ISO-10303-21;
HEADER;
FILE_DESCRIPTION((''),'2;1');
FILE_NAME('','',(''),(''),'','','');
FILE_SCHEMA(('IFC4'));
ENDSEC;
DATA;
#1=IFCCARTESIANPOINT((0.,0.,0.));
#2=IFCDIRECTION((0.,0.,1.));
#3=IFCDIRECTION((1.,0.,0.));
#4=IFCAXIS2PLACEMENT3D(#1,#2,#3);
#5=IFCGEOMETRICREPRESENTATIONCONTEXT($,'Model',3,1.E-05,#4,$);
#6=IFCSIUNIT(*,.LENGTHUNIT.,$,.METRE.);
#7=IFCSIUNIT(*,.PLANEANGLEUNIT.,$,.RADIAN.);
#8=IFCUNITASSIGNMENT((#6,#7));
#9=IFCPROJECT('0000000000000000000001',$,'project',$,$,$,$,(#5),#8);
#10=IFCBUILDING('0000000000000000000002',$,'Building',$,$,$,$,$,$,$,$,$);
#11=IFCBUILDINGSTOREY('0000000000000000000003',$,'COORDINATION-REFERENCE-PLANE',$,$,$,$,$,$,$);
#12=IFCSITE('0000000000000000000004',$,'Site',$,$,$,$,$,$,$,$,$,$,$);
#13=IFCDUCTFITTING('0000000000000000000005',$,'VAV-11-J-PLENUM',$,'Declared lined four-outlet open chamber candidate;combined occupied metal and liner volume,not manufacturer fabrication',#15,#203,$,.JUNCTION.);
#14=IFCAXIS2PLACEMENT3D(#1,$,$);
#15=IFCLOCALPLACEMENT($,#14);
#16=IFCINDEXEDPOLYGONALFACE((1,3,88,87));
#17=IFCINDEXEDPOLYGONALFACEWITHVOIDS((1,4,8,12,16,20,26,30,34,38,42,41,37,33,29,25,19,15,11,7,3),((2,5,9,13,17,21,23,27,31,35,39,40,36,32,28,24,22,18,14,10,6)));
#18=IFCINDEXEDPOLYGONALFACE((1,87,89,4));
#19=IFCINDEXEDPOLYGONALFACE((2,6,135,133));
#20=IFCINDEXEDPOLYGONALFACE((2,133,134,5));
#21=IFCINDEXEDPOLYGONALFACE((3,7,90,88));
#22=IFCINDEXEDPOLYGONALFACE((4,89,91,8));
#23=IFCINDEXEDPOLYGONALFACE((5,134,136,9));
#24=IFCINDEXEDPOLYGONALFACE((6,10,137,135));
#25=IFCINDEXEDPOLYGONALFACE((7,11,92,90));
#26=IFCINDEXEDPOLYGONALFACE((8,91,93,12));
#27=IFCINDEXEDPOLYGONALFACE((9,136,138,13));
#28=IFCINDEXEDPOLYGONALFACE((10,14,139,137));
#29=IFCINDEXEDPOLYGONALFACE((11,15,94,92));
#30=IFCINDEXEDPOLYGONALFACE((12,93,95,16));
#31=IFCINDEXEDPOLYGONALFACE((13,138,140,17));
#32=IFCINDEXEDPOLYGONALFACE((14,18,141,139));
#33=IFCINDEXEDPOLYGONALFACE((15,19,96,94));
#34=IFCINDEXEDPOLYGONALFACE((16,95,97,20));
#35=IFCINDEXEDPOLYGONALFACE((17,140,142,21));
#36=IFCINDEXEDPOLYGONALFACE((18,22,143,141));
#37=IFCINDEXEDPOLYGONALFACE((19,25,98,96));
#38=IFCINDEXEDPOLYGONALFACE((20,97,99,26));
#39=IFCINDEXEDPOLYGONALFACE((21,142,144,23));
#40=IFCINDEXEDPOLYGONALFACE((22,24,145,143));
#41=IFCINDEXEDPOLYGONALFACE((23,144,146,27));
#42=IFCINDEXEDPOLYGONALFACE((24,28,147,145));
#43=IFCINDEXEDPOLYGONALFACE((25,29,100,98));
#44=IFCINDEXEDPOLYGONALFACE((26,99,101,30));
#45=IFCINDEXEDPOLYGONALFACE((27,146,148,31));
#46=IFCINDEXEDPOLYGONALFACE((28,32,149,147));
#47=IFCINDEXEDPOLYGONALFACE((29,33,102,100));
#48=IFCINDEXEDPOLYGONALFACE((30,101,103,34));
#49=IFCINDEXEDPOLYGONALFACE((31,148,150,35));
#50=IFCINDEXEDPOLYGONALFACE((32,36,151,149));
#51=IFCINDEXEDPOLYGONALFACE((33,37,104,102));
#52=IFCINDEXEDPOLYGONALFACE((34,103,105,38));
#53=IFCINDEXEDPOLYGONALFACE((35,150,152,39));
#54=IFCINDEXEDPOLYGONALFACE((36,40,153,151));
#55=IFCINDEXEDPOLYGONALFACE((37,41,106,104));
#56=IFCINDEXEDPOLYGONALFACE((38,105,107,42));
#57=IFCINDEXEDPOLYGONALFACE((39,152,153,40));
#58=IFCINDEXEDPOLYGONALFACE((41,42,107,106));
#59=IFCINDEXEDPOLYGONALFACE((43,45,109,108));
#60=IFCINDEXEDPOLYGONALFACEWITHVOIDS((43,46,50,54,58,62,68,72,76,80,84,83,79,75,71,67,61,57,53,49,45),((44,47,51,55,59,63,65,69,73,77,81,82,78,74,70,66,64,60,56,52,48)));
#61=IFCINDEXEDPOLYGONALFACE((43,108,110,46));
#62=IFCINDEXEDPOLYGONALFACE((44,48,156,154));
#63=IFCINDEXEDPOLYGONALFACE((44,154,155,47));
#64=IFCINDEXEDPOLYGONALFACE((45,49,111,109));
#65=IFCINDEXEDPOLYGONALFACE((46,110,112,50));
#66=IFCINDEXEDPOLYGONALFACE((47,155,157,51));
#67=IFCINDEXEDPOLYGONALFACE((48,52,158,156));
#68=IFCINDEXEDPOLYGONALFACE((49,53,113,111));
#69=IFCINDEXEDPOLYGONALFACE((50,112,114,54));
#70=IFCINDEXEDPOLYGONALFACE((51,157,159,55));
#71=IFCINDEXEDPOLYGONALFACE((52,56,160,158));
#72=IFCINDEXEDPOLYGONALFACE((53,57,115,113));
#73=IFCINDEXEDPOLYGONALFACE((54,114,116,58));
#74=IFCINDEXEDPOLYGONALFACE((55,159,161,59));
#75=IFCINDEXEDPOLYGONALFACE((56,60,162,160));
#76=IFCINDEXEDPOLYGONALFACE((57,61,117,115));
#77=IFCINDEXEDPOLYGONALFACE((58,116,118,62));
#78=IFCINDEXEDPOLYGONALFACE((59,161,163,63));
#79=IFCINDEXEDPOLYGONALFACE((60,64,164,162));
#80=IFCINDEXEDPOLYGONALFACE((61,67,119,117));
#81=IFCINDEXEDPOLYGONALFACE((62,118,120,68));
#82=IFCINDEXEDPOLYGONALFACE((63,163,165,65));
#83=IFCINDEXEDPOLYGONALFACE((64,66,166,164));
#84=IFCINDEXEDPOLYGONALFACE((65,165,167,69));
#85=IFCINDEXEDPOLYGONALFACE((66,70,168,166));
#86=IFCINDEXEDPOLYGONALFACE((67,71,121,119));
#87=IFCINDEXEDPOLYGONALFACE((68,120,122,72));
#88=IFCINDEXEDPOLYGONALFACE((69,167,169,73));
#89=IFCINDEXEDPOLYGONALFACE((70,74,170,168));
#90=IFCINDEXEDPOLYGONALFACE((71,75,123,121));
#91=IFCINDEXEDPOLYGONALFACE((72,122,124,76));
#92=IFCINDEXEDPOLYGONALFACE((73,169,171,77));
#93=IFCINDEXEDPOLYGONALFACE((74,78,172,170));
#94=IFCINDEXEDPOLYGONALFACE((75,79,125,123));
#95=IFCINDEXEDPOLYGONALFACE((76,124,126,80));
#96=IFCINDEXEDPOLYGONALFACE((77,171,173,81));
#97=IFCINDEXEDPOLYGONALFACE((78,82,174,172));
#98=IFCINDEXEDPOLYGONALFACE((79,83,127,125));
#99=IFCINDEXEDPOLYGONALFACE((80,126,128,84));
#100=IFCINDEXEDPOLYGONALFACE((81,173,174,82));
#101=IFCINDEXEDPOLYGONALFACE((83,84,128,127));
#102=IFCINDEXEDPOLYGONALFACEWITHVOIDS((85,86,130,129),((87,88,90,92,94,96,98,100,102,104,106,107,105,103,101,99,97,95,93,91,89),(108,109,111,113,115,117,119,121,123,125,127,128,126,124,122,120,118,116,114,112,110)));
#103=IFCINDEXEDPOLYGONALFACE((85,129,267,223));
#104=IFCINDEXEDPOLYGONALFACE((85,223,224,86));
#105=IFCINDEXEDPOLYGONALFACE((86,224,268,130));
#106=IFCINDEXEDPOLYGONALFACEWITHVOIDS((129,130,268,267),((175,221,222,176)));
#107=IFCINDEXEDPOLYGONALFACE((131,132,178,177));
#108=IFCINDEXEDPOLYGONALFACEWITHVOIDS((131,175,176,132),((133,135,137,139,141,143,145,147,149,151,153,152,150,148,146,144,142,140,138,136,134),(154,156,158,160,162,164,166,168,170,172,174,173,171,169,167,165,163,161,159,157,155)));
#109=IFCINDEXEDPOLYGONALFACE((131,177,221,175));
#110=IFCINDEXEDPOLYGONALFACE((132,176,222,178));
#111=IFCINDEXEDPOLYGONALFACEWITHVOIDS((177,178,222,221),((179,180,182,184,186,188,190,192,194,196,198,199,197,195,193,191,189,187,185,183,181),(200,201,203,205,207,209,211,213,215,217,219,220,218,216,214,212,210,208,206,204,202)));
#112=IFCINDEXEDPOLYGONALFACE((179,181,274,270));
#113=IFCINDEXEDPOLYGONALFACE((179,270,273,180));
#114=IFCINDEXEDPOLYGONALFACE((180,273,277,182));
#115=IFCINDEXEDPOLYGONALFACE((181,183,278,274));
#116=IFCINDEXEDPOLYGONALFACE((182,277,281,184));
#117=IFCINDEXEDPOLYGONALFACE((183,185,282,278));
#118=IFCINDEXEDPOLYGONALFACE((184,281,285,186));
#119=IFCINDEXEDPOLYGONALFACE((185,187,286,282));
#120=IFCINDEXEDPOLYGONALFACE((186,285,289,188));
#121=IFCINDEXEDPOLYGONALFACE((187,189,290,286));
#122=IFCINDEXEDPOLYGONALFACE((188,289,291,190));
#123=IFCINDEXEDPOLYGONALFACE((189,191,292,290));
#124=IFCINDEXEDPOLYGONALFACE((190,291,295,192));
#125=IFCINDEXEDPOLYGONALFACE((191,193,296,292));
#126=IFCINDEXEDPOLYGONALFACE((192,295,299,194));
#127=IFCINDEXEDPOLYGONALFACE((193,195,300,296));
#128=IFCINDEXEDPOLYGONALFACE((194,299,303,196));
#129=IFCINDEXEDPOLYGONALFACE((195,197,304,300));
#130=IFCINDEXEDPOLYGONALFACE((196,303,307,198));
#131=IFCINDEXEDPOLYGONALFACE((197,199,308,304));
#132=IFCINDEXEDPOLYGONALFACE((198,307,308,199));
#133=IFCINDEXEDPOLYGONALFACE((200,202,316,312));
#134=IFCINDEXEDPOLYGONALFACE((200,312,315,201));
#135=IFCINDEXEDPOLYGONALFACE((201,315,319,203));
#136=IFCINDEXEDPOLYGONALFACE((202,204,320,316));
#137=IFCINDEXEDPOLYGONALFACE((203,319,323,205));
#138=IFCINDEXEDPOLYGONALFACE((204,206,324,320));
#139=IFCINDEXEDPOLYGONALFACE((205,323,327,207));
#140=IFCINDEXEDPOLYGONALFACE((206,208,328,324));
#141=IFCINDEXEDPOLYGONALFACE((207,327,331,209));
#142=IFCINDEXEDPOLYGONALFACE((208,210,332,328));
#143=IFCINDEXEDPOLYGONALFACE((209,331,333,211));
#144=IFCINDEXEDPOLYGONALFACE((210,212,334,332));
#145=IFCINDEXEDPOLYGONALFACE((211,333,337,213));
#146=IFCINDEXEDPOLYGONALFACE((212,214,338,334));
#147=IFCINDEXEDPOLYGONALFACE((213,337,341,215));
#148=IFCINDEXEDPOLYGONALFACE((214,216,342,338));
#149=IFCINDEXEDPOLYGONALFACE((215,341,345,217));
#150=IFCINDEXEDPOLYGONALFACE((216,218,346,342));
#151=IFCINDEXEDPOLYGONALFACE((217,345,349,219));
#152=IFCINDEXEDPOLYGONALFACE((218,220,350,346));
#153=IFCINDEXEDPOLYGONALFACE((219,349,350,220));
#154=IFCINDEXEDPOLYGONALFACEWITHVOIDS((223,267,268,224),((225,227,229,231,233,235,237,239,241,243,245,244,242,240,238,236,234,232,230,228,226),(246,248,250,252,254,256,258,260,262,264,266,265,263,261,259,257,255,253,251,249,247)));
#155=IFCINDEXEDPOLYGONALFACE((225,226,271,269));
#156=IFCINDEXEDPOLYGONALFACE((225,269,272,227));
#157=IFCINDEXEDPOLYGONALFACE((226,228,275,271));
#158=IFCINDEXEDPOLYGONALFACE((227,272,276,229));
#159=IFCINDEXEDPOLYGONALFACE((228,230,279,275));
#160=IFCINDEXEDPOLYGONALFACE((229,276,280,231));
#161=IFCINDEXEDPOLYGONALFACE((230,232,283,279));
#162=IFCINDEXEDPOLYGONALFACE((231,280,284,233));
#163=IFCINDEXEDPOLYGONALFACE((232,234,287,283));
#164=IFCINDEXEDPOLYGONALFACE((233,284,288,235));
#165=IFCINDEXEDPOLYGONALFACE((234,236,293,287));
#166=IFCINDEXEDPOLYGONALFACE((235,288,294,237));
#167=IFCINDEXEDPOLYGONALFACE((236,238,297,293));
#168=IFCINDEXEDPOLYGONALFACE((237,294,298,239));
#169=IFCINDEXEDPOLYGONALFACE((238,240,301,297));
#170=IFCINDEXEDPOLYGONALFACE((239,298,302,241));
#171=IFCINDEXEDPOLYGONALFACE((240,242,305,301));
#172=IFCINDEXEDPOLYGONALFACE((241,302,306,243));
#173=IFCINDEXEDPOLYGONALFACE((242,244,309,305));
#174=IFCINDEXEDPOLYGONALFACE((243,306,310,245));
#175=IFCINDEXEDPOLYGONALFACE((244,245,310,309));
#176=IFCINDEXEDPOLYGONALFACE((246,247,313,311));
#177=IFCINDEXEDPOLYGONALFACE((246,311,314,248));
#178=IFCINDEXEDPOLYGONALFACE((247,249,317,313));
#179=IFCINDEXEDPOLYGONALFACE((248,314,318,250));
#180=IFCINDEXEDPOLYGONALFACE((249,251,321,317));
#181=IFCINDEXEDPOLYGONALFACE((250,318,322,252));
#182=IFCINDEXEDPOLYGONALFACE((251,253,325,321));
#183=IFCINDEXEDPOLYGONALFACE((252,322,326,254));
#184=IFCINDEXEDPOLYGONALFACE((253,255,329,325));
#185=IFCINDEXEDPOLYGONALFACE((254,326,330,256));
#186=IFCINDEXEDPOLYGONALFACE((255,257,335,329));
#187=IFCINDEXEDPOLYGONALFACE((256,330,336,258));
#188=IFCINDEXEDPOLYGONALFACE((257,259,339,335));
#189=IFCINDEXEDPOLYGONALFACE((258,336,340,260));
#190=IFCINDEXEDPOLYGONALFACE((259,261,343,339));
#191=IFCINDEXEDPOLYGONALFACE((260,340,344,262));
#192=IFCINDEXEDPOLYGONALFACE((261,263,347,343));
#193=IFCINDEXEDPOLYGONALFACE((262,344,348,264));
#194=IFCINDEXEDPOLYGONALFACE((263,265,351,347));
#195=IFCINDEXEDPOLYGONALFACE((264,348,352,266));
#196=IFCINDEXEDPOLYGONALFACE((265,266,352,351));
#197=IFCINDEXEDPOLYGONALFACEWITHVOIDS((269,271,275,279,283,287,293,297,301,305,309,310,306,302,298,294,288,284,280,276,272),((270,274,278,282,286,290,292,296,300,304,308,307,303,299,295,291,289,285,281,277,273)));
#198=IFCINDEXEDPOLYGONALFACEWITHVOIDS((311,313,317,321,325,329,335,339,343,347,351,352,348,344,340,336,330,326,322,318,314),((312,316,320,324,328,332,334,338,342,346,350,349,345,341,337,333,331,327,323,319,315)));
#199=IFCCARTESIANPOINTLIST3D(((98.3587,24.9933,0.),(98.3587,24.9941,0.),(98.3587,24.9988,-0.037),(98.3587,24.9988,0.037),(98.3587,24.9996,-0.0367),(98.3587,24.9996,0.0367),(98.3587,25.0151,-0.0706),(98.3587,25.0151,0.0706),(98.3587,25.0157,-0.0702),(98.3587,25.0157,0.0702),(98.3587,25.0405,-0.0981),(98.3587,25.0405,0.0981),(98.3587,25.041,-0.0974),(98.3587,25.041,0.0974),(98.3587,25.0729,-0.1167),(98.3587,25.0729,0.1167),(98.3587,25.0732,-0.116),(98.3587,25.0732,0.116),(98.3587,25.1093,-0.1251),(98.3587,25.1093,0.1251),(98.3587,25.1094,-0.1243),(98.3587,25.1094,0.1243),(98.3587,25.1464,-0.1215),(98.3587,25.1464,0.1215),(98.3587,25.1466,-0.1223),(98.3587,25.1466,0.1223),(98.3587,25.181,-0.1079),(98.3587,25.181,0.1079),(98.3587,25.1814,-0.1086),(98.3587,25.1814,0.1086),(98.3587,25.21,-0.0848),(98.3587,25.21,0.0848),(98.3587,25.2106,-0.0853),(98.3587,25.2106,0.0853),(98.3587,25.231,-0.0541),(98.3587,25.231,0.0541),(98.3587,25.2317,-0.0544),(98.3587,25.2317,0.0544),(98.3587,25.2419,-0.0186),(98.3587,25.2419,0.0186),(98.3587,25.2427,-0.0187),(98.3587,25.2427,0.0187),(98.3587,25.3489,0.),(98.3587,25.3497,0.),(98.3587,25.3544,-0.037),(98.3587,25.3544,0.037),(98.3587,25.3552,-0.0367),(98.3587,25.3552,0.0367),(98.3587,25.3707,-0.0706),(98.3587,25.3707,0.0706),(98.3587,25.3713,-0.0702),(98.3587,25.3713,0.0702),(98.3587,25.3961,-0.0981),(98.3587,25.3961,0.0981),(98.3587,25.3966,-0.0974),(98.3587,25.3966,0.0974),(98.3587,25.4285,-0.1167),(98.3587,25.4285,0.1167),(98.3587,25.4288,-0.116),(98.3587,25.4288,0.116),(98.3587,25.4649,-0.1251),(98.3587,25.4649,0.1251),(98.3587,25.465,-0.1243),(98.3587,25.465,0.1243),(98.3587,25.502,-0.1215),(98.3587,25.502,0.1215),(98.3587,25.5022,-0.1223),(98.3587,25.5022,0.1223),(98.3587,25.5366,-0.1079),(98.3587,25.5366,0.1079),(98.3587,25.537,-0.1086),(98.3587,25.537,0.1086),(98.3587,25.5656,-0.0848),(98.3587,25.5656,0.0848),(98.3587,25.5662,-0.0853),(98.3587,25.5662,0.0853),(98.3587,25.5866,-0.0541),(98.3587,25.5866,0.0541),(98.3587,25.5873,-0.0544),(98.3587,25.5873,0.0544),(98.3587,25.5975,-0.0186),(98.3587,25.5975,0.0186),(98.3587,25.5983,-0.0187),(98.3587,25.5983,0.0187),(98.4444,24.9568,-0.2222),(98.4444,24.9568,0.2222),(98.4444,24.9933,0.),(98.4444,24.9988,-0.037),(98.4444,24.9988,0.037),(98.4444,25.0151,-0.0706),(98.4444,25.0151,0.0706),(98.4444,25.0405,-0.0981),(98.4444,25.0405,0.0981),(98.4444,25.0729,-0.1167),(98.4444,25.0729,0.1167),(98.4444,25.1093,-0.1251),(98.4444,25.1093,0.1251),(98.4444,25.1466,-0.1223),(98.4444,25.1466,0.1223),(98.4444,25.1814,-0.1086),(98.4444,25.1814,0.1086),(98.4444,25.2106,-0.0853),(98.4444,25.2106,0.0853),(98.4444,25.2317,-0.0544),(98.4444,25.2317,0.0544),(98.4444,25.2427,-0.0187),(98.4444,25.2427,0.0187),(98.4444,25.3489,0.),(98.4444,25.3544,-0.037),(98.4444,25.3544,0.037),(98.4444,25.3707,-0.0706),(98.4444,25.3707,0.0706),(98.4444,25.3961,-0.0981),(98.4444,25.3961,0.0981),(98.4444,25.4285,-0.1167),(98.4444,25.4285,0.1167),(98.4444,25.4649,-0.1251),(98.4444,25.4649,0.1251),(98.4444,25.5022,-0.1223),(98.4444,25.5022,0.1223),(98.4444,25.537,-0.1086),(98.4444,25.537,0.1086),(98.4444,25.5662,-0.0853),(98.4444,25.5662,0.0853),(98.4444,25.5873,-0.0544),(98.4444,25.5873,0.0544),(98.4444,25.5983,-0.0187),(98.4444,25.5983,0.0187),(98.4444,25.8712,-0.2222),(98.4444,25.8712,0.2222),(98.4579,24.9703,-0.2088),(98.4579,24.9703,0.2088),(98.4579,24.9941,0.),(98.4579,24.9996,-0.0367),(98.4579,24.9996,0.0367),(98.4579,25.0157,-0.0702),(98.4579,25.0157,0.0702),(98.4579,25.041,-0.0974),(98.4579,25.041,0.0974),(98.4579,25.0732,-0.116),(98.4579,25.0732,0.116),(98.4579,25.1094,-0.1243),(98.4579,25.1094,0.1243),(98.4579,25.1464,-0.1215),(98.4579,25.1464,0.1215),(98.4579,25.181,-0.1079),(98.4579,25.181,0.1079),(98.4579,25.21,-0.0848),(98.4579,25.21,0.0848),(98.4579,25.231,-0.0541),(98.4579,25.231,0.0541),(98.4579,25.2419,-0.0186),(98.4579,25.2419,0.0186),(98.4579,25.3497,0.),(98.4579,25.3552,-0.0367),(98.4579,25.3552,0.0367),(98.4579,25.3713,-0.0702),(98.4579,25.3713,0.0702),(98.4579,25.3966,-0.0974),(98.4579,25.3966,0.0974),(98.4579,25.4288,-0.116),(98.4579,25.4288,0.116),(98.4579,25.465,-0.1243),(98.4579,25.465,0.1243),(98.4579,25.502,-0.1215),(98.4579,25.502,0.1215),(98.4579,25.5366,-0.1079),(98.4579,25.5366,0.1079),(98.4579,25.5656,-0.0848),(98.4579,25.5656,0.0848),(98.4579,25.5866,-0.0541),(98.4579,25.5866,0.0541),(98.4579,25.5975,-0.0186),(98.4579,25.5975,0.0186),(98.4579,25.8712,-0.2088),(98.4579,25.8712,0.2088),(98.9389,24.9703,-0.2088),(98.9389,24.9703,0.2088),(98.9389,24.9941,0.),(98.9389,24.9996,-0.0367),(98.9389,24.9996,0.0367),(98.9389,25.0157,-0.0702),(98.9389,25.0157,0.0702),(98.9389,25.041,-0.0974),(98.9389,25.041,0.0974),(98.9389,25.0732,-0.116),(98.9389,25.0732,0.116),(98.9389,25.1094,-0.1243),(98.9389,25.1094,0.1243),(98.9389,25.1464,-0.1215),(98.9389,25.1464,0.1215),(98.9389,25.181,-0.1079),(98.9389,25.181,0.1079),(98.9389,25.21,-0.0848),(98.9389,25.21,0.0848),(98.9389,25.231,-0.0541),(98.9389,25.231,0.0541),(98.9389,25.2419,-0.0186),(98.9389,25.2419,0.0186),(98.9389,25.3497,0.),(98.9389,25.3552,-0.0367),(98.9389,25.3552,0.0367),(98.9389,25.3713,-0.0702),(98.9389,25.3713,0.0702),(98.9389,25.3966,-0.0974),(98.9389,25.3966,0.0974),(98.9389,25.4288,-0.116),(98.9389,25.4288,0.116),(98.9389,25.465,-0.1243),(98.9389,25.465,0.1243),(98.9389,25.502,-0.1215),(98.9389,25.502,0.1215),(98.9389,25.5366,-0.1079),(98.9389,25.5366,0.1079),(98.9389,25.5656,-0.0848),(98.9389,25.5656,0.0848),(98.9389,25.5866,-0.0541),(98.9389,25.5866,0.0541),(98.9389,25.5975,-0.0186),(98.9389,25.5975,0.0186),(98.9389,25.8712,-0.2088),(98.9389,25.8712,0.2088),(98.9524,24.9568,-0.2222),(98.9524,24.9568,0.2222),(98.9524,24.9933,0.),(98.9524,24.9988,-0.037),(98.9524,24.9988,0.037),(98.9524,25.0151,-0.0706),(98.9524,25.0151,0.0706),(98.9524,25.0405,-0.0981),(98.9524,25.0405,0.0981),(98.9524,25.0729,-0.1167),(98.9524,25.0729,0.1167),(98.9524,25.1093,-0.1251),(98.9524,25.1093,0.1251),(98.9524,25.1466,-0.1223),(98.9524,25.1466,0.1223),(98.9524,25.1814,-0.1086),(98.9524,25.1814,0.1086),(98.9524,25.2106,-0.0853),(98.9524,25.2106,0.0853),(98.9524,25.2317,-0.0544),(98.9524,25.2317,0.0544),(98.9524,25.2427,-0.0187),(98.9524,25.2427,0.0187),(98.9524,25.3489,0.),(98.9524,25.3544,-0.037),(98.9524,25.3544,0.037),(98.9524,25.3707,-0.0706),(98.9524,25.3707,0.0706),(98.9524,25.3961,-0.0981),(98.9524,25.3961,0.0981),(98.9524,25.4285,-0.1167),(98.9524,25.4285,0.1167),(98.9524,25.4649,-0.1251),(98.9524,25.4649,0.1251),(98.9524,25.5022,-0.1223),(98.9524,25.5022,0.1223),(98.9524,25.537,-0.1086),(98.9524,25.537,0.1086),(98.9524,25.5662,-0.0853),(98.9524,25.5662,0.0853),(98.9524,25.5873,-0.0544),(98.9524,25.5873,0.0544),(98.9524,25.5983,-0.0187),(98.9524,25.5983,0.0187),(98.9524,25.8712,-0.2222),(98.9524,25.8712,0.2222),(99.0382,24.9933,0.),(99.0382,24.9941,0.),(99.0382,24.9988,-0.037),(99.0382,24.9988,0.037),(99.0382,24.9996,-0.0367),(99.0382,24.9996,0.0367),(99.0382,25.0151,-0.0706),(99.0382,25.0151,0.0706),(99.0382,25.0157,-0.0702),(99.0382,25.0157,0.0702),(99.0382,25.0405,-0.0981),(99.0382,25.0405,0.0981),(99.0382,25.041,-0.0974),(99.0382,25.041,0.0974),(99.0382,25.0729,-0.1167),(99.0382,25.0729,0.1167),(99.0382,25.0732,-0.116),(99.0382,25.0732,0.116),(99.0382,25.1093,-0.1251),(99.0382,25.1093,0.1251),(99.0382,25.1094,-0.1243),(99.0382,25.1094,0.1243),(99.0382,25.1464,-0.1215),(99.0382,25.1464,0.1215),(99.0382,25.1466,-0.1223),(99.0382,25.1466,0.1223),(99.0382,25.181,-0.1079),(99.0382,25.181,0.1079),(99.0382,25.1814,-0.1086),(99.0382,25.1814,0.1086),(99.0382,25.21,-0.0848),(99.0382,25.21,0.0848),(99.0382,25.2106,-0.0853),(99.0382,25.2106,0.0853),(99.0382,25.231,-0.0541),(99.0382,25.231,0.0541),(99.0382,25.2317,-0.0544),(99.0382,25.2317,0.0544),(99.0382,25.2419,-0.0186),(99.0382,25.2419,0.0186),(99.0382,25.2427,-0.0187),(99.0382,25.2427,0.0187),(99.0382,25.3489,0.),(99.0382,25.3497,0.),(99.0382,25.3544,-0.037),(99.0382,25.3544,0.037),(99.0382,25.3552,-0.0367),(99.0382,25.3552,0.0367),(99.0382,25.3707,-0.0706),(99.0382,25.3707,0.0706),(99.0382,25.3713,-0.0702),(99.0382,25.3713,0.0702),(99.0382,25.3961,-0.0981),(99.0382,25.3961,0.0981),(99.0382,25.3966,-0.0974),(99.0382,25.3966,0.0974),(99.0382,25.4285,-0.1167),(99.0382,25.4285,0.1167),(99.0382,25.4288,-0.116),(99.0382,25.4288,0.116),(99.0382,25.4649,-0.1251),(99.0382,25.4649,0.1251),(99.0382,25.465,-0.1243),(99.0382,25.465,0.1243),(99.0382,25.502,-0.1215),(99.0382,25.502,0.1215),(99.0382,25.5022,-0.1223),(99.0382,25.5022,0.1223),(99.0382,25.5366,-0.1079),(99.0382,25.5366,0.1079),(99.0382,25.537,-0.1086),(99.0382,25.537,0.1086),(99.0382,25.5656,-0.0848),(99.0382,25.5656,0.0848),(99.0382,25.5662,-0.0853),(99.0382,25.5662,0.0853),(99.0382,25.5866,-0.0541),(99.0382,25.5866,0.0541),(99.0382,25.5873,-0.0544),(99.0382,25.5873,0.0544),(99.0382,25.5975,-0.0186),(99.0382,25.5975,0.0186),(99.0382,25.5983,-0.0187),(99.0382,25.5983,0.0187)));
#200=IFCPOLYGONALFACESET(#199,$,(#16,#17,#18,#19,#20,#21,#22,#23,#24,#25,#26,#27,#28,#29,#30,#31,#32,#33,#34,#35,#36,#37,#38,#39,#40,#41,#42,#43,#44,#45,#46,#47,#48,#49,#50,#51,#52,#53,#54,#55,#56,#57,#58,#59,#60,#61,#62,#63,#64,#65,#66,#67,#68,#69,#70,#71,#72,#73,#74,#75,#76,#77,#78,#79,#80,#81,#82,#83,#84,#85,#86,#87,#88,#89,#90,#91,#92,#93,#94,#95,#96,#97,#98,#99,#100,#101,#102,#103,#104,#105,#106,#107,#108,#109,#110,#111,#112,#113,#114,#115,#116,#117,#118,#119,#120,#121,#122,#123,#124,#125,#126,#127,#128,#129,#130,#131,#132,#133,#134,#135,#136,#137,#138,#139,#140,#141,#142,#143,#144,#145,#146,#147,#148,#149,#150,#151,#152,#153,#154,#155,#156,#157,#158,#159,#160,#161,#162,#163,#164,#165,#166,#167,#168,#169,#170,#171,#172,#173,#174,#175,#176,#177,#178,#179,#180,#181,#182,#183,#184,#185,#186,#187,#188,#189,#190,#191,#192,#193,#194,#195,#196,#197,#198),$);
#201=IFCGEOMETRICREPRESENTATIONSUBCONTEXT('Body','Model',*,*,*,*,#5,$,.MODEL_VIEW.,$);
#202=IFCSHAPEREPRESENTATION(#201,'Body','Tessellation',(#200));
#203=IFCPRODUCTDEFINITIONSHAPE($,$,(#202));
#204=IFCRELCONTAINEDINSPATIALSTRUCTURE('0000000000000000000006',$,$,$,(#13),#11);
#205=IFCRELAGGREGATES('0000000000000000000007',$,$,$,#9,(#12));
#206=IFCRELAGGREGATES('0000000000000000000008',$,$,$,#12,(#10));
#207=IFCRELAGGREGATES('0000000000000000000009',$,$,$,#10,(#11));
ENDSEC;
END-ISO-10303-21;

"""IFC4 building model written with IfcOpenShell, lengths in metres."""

from ifc_helpers import new_model, si_unit, frame, origin_with_axes, place, context, subcontext, project, spatial, rectangle, circle, extrude, boolean, element, save


model = new_model("IFC4")

# Units and contexts
model_context = context("Model", 3, precision=1e-05, world=origin_with_axes())
body_context_1 = subcontext(model_context, "Body", "Model", "MODEL_VIEW")
ifc_project = project(units=[si_unit("LENGTHUNIT", "METRE"), si_unit("PLANEANGLEUNIT", "RADIAN")], contexts=[model_context])

# Site, building, storey
site = spatial("IfcSite", under=ifc_project, Name="Site")
building = spatial("IfcBuilding", under=site, Name="Building")
storey = spatial("IfcBuildingStorey", under=building, Name="COORDINATION-REFERENCE-PLANE")

# Duct fitting
duct_fitting_1_placement = place(None, frame((98.4444, 24.9568, -0.2223), z_axis=(0.0, 0.0, 1.0), x_axis=(1.0, 0.0, 0.0)))
solid_1 = boolean("UNION", boolean("UNION", boolean("UNION", boolean("UNION", extrude(rectangle(XDim=0.481, YDim=0.4175), frame((0.254, 0.9244, 0.2223), z_axis=(0.0, -1.0, 0.0), x_axis=(1.0, 0.0, 0.0)), (0.0, 0.0, 1.0), 0.9109), extrude(circle(Radius=0.1246), frame((0.0235, 0.5175, 0.2223), z_axis=(-1.0, 0.0, 0.0), x_axis=(0.0, -1.0, 0.0)), (0.0, 0.0, 1.0), 0.1192)), extrude(circle(Radius=0.1246), frame((0.4845, 0.5175, 0.2223), z_axis=(1.0, 0.0, 0.0), x_axis=(0.0, -1.0, 0.0)), (0.0, 0.0, 1.0), 0.1192)), extrude(circle(Radius=0.1246), frame((0.0235, 0.1619, 0.2223), z_axis=(-1.0, 0.0, 0.0), x_axis=(0.0, -1.0, 0.0)), (0.0, 0.0, 1.0), 0.1192)), extrude(circle(Radius=0.1246), frame((0.4845, 0.1619, 0.2223), z_axis=(1.0, 0.0, 0.0), x_axis=(0.0, -1.0, 0.0)), (0.0, 0.0, 1.0), 0.1192))
element("IfcDuctFitting", 1, at=duct_fitting_1_placement, inside=storey, Name="VAV-11-J-PLENUM", ObjectType="Declared lined four-outlet open chamber candidate;combined occupied metal and liner volume,not manufacturer fabrication", PredefinedType="JUNCTION", context=body_context_1, shape_type="CSG", body=[
    boolean("DIFFERENCE", boolean("UNION", boolean("UNION", boolean("UNION", boolean("UNION", extrude(rectangle(XDim=0.508, YDim=0.4445), frame((0.254, 0.9144, 0.2223), z_axis=(0.0, -1.0, 0.0), x_axis=(1.0, 0.0, 0.0)), (0.0, 0.0, 1.0), 0.9144), extrude(circle(Radius=0.1254), frame((0.0235, 0.5175, 0.2223), z_axis=(-1.0, 0.0, 0.0), x_axis=(0.0, -1.0, 0.0)), (0.0, 0.0, 1.0), 0.1092)), extrude(circle(Radius=0.1254), frame((0.4845, 0.5175, 0.2223), z_axis=(1.0, 0.0, 0.0), x_axis=(0.0, -1.0, 0.0)), (0.0, 0.0, 1.0), 0.1092)), extrude(circle(Radius=0.1254), frame((0.0235, 0.1619, 0.2223), z_axis=(-1.0, 0.0, 0.0), x_axis=(0.0, -1.0, 0.0)), (0.0, 0.0, 1.0), 0.1092)), extrude(circle(Radius=0.1254), frame((0.4845, 0.1619, 0.2223), z_axis=(1.0, 0.0, 0.0), x_axis=(0.0, -1.0, 0.0)), (0.0, 0.0, 1.0), 0.1092)), solid_1),
])

save(model, "model.ifc")
